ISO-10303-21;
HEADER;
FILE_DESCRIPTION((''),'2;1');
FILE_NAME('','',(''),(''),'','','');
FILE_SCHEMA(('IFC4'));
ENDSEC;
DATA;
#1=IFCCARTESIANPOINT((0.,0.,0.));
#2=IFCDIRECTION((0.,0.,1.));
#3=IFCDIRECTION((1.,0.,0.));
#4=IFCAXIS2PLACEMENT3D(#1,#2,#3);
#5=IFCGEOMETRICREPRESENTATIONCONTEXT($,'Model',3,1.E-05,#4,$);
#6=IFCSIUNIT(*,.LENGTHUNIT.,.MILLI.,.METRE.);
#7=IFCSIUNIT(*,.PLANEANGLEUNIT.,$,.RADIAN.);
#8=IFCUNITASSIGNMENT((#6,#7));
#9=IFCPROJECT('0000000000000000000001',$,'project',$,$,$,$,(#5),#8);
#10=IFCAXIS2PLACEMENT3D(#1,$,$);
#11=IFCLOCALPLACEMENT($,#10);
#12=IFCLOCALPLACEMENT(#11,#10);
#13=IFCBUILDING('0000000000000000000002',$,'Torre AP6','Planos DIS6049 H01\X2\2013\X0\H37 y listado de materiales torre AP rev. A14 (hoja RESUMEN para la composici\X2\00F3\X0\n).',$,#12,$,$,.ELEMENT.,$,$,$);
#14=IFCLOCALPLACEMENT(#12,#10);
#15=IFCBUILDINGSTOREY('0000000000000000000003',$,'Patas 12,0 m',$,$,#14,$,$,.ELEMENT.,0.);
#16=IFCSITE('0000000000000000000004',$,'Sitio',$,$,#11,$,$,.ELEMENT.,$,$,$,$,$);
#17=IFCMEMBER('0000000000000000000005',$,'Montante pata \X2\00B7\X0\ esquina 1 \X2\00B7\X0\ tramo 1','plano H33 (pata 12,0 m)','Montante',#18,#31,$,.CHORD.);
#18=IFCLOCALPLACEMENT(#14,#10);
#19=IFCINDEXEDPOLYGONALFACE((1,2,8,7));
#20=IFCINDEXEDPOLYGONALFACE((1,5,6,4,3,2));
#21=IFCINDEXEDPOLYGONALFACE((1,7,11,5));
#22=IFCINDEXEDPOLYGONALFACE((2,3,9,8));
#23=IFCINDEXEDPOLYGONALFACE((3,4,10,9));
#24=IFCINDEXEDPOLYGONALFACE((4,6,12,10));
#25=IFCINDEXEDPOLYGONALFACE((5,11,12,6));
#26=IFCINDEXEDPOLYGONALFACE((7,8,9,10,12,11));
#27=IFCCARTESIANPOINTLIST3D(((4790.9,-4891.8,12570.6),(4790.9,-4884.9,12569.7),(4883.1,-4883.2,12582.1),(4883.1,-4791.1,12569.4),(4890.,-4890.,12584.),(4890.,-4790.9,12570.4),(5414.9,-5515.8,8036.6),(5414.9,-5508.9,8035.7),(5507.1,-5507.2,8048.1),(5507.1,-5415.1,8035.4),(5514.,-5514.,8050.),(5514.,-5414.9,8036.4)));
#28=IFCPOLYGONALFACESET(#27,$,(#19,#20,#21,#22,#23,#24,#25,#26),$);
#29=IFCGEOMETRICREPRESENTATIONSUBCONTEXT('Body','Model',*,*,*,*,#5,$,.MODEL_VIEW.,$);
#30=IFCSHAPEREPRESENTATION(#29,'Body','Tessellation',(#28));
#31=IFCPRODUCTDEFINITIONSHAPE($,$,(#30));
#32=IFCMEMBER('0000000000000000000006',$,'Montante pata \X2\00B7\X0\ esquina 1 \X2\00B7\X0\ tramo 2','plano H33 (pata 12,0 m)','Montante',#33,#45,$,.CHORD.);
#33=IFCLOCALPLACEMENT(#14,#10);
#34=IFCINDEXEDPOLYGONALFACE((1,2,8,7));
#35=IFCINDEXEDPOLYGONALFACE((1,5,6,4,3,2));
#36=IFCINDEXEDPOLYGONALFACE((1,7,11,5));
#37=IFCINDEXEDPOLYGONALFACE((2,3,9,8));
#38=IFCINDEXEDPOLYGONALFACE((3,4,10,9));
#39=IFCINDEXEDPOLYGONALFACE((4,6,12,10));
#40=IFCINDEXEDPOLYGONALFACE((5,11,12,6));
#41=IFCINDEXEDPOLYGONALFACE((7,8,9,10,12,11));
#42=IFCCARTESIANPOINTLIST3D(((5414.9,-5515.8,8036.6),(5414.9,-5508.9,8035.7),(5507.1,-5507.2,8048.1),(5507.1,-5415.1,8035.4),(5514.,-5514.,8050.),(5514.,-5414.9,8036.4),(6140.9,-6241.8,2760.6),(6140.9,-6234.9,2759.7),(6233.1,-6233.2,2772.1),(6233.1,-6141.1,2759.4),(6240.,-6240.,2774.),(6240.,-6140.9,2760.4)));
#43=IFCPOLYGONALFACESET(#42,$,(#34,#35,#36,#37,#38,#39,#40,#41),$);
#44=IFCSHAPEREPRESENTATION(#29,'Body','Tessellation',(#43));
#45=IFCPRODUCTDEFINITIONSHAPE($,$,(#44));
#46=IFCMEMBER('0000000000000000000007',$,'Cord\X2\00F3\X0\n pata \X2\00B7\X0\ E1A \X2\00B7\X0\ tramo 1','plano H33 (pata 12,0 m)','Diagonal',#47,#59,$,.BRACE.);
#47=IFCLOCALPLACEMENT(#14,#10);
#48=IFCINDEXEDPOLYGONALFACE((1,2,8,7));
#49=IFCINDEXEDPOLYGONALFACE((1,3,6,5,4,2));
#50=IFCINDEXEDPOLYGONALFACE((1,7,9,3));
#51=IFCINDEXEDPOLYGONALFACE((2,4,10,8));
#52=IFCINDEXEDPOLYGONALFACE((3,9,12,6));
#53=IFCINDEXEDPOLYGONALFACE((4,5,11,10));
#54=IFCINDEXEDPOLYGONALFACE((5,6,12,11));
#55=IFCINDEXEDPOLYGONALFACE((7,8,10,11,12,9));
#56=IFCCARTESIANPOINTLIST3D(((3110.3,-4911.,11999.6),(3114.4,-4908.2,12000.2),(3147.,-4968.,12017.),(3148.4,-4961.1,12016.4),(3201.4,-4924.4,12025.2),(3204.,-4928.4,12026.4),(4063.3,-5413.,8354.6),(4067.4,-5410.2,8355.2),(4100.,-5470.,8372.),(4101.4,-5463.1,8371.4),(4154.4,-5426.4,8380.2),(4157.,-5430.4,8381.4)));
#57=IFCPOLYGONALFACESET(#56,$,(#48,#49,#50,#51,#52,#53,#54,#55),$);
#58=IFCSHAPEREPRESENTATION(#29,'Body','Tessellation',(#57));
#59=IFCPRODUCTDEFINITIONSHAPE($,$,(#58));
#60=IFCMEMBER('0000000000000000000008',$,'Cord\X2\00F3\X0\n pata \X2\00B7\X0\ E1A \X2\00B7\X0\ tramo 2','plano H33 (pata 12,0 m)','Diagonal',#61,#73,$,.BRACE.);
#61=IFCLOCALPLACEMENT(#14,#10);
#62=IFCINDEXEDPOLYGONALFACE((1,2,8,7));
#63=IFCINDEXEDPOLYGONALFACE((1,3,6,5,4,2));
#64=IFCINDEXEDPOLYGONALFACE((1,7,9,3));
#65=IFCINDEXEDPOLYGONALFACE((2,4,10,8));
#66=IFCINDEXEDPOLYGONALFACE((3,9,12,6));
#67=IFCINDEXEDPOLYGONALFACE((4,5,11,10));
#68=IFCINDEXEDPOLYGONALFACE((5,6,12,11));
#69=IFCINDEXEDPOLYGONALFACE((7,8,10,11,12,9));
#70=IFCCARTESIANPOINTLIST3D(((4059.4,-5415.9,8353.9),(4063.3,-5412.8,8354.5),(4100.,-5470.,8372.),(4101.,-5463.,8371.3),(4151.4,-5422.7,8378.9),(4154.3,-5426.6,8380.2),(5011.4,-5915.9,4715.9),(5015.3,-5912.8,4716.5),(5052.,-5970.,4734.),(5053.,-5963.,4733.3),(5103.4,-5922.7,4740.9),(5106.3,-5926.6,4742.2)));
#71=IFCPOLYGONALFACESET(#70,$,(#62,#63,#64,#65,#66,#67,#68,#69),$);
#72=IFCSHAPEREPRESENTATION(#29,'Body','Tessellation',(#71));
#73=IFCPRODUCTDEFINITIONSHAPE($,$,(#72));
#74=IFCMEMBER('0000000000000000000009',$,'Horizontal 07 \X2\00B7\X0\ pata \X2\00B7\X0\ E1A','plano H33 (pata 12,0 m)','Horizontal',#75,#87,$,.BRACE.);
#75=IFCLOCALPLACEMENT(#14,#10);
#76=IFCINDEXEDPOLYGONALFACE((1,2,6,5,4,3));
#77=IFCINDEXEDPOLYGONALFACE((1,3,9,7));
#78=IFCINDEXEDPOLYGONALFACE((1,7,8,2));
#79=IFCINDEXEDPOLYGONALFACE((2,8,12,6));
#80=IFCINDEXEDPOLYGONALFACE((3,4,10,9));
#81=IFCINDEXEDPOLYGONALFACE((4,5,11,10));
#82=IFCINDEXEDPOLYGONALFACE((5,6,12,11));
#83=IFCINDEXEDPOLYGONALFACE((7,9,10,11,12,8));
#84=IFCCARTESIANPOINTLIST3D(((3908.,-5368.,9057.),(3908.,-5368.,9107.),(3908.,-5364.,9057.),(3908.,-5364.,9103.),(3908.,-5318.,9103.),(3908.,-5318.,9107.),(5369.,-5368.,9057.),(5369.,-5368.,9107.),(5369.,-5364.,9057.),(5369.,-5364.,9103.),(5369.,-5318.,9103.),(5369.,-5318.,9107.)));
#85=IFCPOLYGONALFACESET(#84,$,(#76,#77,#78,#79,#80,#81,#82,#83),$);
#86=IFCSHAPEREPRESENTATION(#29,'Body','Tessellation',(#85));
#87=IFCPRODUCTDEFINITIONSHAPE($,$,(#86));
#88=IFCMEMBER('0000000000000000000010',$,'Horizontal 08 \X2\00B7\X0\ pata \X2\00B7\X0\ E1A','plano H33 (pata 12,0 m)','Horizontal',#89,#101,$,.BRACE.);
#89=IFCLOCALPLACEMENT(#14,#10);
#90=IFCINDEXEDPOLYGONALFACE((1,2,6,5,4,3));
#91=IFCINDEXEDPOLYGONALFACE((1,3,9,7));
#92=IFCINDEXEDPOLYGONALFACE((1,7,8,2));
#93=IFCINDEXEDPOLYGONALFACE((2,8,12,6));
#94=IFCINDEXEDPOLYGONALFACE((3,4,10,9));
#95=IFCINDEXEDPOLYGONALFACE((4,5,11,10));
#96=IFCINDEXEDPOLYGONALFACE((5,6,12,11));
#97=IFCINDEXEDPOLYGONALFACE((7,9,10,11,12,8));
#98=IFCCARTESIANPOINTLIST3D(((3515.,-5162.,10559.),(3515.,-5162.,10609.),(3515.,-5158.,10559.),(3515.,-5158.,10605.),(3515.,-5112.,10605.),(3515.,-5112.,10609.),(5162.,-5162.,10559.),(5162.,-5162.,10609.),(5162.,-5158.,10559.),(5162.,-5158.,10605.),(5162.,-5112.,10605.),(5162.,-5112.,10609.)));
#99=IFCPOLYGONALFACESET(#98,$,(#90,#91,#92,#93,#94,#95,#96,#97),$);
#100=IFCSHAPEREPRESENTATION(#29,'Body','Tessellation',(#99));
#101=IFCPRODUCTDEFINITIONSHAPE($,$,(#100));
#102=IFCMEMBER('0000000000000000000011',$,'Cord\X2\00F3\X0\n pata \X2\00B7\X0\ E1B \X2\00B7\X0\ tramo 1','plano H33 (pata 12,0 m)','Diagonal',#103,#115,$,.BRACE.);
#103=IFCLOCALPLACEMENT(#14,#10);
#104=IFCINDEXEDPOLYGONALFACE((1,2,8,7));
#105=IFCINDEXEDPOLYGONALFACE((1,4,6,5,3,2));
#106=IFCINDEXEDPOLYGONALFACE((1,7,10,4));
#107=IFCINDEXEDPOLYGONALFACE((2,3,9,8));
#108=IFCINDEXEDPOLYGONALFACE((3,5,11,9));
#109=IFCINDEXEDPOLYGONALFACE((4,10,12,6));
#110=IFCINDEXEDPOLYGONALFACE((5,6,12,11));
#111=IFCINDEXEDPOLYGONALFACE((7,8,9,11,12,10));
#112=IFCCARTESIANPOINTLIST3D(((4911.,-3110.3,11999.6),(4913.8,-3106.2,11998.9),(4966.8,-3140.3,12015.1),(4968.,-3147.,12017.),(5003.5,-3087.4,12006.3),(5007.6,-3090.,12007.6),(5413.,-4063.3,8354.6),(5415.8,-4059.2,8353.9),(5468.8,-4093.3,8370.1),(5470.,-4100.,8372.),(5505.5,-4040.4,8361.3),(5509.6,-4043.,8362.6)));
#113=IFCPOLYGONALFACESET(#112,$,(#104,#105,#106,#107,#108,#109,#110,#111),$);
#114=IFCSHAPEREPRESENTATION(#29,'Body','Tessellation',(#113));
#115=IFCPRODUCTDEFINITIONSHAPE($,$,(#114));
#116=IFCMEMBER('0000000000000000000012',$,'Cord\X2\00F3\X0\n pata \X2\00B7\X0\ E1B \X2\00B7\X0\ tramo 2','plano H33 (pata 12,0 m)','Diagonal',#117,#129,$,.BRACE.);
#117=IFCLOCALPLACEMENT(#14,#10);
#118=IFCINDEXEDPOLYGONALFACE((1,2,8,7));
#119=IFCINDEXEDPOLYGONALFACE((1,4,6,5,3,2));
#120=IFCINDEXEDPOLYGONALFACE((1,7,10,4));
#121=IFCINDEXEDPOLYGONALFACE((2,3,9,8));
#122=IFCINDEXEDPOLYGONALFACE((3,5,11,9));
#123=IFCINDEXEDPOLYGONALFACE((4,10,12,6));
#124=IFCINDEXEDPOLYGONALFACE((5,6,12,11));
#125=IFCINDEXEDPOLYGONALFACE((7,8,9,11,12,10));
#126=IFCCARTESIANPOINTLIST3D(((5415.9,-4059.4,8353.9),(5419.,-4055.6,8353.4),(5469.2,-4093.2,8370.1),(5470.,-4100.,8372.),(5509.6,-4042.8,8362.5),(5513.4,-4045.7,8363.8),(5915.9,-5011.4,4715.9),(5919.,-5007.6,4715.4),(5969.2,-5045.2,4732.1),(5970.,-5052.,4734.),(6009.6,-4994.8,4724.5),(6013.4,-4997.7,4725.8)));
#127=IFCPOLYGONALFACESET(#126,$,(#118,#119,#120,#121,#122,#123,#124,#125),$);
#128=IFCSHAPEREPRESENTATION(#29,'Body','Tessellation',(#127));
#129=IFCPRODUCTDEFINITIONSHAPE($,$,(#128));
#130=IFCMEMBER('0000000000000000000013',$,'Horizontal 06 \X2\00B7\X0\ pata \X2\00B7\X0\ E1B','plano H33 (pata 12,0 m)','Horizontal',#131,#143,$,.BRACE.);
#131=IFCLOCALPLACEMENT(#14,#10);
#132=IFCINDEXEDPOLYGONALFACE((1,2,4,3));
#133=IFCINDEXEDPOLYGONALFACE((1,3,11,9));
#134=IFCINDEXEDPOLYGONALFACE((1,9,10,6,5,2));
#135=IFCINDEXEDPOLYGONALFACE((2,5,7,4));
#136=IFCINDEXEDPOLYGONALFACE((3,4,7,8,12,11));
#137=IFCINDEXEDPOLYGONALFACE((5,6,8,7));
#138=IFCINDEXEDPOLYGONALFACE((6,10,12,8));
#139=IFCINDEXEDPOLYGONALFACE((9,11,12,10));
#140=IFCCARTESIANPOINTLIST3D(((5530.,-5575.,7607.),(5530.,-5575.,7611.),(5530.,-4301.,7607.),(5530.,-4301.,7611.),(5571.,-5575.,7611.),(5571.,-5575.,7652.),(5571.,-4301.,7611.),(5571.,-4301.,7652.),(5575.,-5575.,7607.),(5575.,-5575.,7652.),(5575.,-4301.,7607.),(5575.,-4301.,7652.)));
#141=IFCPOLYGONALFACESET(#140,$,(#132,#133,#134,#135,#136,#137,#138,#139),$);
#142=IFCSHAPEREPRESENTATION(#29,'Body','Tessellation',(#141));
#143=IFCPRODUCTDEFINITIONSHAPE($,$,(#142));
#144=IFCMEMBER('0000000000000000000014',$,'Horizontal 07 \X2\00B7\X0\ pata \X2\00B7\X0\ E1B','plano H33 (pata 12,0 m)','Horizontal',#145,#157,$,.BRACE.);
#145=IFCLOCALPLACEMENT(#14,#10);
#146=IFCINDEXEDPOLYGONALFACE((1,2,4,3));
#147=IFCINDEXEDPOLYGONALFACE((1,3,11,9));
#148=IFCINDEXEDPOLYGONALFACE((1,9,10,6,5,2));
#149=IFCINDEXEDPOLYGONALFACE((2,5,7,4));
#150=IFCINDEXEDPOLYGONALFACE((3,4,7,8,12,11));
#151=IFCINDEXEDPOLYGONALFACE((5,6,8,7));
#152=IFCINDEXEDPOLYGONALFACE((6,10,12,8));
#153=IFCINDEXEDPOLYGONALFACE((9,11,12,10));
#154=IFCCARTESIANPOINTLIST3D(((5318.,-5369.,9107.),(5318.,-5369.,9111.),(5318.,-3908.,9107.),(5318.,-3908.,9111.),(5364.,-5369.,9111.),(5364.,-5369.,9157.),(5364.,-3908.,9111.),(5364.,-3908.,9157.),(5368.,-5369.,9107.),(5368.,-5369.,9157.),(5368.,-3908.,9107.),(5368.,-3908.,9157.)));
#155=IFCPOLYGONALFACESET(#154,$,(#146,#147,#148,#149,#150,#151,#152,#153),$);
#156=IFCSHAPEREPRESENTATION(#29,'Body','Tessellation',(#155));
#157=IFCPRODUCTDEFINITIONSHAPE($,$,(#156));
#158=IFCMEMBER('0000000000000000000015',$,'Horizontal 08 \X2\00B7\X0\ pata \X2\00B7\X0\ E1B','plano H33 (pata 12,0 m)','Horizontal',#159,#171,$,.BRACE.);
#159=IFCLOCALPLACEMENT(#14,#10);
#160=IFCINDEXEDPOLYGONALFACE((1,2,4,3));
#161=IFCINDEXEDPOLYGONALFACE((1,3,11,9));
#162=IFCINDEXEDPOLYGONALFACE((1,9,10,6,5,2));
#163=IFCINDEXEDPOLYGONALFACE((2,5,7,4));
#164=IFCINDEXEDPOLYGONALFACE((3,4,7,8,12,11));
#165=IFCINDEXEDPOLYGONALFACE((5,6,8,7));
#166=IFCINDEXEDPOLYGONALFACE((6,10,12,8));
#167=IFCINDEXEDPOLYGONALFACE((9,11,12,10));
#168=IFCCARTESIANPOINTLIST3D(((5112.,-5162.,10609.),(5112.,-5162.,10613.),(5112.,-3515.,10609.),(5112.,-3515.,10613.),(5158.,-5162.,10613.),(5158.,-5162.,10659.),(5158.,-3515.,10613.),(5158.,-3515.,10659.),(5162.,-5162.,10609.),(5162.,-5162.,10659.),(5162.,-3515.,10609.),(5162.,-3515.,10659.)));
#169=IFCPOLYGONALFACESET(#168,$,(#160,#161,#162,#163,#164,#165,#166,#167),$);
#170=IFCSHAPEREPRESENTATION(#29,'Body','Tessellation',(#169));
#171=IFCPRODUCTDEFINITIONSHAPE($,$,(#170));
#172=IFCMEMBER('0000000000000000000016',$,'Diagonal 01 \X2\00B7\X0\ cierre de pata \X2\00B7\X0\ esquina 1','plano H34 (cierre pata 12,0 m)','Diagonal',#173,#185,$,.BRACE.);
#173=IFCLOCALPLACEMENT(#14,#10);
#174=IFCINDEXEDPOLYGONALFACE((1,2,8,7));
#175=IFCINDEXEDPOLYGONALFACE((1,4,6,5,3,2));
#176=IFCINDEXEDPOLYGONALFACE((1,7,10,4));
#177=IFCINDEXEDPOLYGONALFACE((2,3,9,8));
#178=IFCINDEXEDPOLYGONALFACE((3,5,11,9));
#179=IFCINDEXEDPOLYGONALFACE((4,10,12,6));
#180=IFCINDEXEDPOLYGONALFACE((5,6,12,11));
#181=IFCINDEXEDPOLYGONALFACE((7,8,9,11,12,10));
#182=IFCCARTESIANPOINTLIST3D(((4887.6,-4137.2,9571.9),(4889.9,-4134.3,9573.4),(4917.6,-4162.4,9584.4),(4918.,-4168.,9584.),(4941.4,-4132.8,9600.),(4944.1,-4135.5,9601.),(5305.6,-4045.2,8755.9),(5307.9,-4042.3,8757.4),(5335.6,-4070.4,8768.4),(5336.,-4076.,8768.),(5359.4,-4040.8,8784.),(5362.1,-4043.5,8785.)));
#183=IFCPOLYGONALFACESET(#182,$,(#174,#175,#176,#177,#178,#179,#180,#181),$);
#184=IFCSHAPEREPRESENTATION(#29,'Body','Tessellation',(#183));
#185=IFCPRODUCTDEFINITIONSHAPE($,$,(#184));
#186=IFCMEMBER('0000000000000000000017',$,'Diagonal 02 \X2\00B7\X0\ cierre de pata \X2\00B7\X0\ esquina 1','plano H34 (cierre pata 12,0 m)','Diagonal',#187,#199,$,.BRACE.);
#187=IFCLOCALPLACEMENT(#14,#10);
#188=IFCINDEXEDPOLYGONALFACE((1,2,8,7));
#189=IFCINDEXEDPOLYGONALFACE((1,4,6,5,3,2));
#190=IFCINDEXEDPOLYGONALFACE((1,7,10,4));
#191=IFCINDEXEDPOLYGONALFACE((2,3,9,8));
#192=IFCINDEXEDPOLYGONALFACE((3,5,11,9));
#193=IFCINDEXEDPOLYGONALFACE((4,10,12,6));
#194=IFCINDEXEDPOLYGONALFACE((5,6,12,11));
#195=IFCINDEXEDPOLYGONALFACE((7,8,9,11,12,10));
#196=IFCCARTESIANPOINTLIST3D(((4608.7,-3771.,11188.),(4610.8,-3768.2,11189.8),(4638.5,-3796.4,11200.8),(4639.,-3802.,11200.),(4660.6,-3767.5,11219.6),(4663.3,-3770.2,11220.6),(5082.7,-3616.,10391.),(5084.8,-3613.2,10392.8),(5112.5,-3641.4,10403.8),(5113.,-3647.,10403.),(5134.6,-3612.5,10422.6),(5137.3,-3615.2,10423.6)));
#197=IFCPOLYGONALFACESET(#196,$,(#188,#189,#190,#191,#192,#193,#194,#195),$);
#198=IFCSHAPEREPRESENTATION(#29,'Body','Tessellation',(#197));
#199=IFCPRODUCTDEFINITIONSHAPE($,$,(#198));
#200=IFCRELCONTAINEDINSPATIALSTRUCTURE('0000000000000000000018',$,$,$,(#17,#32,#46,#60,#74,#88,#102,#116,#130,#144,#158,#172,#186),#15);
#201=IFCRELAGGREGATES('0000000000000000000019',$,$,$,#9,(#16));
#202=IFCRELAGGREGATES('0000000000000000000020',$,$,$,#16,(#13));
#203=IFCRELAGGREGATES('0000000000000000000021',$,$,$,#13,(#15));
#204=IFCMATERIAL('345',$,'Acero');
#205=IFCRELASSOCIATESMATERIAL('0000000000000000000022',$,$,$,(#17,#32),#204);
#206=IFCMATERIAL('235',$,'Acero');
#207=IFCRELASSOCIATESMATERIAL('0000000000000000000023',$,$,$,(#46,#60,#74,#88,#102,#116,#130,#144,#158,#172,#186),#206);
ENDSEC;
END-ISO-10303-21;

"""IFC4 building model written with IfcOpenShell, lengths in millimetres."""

from ifc_helpers import new_model, si_unit, frame, frame_2d, origin, origin_with_axes, place, context, subcontext, project, spatial, l_section, extrude, material, element, save


model = new_model("IFC4")

# Units and contexts
model_context = context("Model", 3, precision=1e-05, world=origin_with_axes())
body_context = subcontext(model_context, "Body", "Model", "MODEL_VIEW")
ifc_project = project(units=[si_unit("LENGTHUNIT", "METRE", prefix="MILLI"), si_unit("PLANEANGLEUNIT", "RADIAN")], contexts=[model_context])

# Site, building, storey
site_placement = place(None, origin())
site = spatial("IfcSite", under=ifc_project, at=site_placement, Name="Sitio", CompositionType="ELEMENT")
building_placement = place(site_placement, origin())
building = spatial("IfcBuilding", under=site, at=building_placement, Name="Torre AP6", Description="Planos DIS6049 H01–H37 y listado de materiales torre AP rev. A14 (hoja RESUMEN para la composición).", CompositionType="ELEMENT")
storey_placement = place(building_placement, origin())
storey = spatial("IfcBuildingStorey", under=building, at=storey_placement, Name="Patas 12,0 m", CompositionType="ELEMENT", Elevation=0.0)

# Members
ifc_material_1 = material(Name="345", Category="Acero")
member_1_placement = place(storey_placement, frame((4890.0, -4890.0, 12584.0), z_axis=(0.135092, -0.135092, -0.981581), x_axis=(-0.990833, -0.018419, -0.13383)))
element("IfcMember", 1, at=member_1_placement, inside=storey, material=ifc_material_1, Name="Montante pata · esquina 1 · tramo 1", Description="plano H33 (pata 12,0 m)", ObjectType="Montante", PredefinedType="CHORD", context=body_context, shape_type="SweptSolid", body=[
    extrude(l_section(Depth=100.0, Width=100.0, Thickness=7.0, at=frame_2d((50.0, 50.0))), None, (0.0, 0.0, 1.0), 4619.1),
])
member_2_placement = place(storey_placement, frame((5514.0, -5514.0, 8050.0), z_axis=(0.13507, -0.13507, -0.981586), x_axis=(-0.990836, -0.018413, -0.13381)))
element("IfcMember", 2, at=member_2_placement, inside=storey, material=ifc_material_1, Name="Montante pata · esquina 1 · tramo 2", Description="plano H33 (pata 12,0 m)", ObjectType="Montante", PredefinedType="CHORD", context=body_context, shape_type="SweptSolid", body=[
    extrude(l_section(Depth=100.0, Width=100.0, Thickness=7.0, at=frame_2d((50.0, 50.0))), None, (0.0, 0.0, 1.0), 5375.0),
])
ifc_material_2 = material(Name="235", Category="Acero")
member_3_placement = place(storey_placement, frame((3147.0, -4968.0, 12017.0), z_axis=(0.250735, -0.132077, -0.959003), x_axis=(-0.524098, 0.814388, -0.249187)))
element("IfcMember", 3, at=member_3_placement, inside=storey, material=ifc_material_2, Name="Cordón pata · E1A · tramo 1", Description="plano H33 (pata 12,0 m)", ObjectType="Diagonal", PredefinedType="BRACE", context=body_context, shape_type="SweptSolid", body=[
    extrude(l_section(Depth=70.0, Width=70.0, Thickness=5.0, at=frame_2d((35.0, 35.0))), None, (0.0, 0.0, 1.0), 3800.8),
])
member_4_placement = place(storey_placement, frame((4100.0, -5470.0, 8372.0), z_axis=(0.250949, -0.131801, -0.958985), x_axis=(-0.579405, 0.773167, -0.257883)))
element("IfcMember", 4, at=member_4_placement, inside=storey, material=ifc_material_2, Name="Cordón pata · E1A · tramo 2", Description="plano H33 (pata 12,0 m)", ObjectType="Diagonal", PredefinedType="BRACE", context=body_context, shape_type="SweptSolid", body=[
    extrude(l_section(Depth=70.0, Width=70.0, Thickness=5.0, at=frame_2d((35.0, 35.0))), None, (0.0, 0.0, 1.0), 3793.6),
])
member_5_placement = place(storey_placement, frame((5369.0, -5368.0, 9107.0), z_axis=(-1.0, 0.0, 0.0), x_axis=(0.0, 1.0, 0.0)))
element("IfcMember", 5, at=member_5_placement, inside=storey, material=ifc_material_2, Name="Horizontal 07 · pata · E1A", Description="plano H33 (pata 12,0 m)", ObjectType="Horizontal", PredefinedType="BRACE", context=body_context, shape_type="SweptSolid", body=[
    extrude(l_section(Depth=50.0, Width=50.0, Thickness=4.0, at=frame_2d((25.0, 25.0))), None, (0.0, 0.0, 1.0), 1461.0),
])
member_6_placement = place(storey_placement, frame((5162.0, -5162.0, 10609.0), z_axis=(-1.0, 0.0, 0.0), x_axis=(0.0, 1.0, 0.0)))
element("IfcMember", 6, at=member_6_placement, inside=storey, material=ifc_material_2, Name="Horizontal 08 · pata · E1A", Description="plano H33 (pata 12,0 m)", ObjectType="Horizontal", PredefinedType="BRACE", context=body_context, shape_type="SweptSolid", body=[
    extrude(l_section(Depth=50.0, Width=50.0, Thickness=4.0, at=frame_2d((25.0, 25.0))), None, (0.0, 0.0, 1.0), 1647.0),
])
member_7_placement = place(storey_placement, frame((4968.0, -3147.0, 12017.0), z_axis=(0.132077, -0.250735, -0.959003), x_axis=(-0.814388, 0.524098, -0.249187)))
element("IfcMember", 7, at=member_7_placement, inside=storey, material=ifc_material_2, Name="Cordón pata · E1B · tramo 1", Description="plano H33 (pata 12,0 m)", ObjectType="Diagonal", PredefinedType="BRACE", context=body_context, shape_type="SweptSolid", body=[
    extrude(l_section(Depth=70.0, Width=70.0, Thickness=5.0, at=frame_2d((35.0, 35.0))), None, (0.0, 0.0, 1.0), 3800.8),
])
member_8_placement = place(storey_placement, frame((5470.0, -4100.0, 8372.0), z_axis=(0.131801, -0.250949, -0.958985), x_axis=(-0.773167, 0.579405, -0.257883)))
element("IfcMember", 8, at=member_8_placement, inside=storey, material=ifc_material_2, Name="Cordón pata · E1B · tramo 2", Description="plano H33 (pata 12,0 m)", ObjectType="Diagonal", PredefinedType="BRACE", context=body_context, shape_type="SweptSolid", body=[
    extrude(l_section(Depth=70.0, Width=70.0, Thickness=5.0, at=frame_2d((35.0, 35.0))), None, (0.0, 0.0, 1.0), 3793.6),
])
member_9_placement = place(storey_placement, frame((5575.0, -5575.0, 7607.0), z_axis=(0.0, 1.0, 0.0), x_axis=(-1.0, 0.0, 0.0)))
element("IfcMember", 9, at=member_9_placement, inside=storey, material=ifc_material_2, Name="Horizontal 06 · pata · E1B", Description="plano H33 (pata 12,0 m)", ObjectType="Horizontal", PredefinedType="BRACE", context=body_context, shape_type="SweptSolid", body=[
    extrude(l_section(Depth=45.0, Width=45.0, Thickness=4.0, at=frame_2d((22.5, 22.5))), None, (0.0, 0.0, 1.0), 1274.0),
])
member_10_placement = place(storey_placement, frame((5368.0, -5369.0, 9107.0), z_axis=(0.0, 1.0, 0.0), x_axis=(-1.0, 0.0, 0.0)))
element("IfcMember", 10, at=member_10_placement, inside=storey, material=ifc_material_2, Name="Horizontal 07 · pata · E1B", Description="plano H33 (pata 12,0 m)", ObjectType="Horizontal", PredefinedType="BRACE", context=body_context, shape_type="SweptSolid", body=[
    extrude(l_section(Depth=50.0, Width=50.0, Thickness=4.0, at=frame_2d((25.0, 25.0))), None, (0.0, 0.0, 1.0), 1461.0),
])
member_11_placement = place(storey_placement, frame((5162.0, -5162.0, 10609.0), z_axis=(0.0, 1.0, 0.0), x_axis=(-1.0, 0.0, 0.0)))
element("IfcMember", 11, at=member_11_placement, inside=storey, material=ifc_material_2, Name="Horizontal 08 · pata · E1B", Description="plano H33 (pata 12,0 m)", ObjectType="Horizontal", PredefinedType="BRACE", context=body_context, shape_type="SweptSolid", body=[
    extrude(l_section(Depth=50.0, Width=50.0, Thickness=4.0, at=frame_2d((25.0, 25.0))), None, (0.0, 0.0, 1.0), 1647.0),
])
member_12_placement = place(storey_placement, frame((4918.0, -4168.0, 9584.0), z_axis=(0.45364, 0.099844, -0.885574), x_axis=(-0.676631, 0.685291, -0.269344)))
element("IfcMember", 12, at=member_12_placement, inside=storey, material=ifc_material_2, Name="Diagonal 01 · cierre de pata · esquina 1", Description="plano H34 (cierre pata 12,0 m)", ObjectType="Diagonal", PredefinedType="BRACE", context=body_context, shape_type="SweptSolid", body=[
    extrude(l_section(Depth=45.0, Width=45.0, Thickness=4.0, at=frame_2d((22.5, 22.5))), None, (0.0, 0.0, 1.0), 921.4),
])
member_13_placement = place(storey_placement, frame((4639.0, -3802.0, 11200.0), z_axis=(0.504167, 0.164865, -0.847724), x_axis=(-0.674329, 0.688407, -0.267163)))
element("IfcMember", 13, at=member_13_placement, inside=storey, material=ifc_material_2, Name="Diagonal 02 · cierre de pata · esquina 1", Description="plano H34 (cierre pata 12,0 m)", ObjectType="Diagonal", PredefinedType="BRACE", context=body_context, shape_type="SweptSolid", body=[
    extrude(l_section(Depth=45.0, Width=45.0, Thickness=4.0, at=frame_2d((22.5, 22.5))), None, (0.0, 0.0, 1.0), 940.2),
])

save(model, "model.ifc")
